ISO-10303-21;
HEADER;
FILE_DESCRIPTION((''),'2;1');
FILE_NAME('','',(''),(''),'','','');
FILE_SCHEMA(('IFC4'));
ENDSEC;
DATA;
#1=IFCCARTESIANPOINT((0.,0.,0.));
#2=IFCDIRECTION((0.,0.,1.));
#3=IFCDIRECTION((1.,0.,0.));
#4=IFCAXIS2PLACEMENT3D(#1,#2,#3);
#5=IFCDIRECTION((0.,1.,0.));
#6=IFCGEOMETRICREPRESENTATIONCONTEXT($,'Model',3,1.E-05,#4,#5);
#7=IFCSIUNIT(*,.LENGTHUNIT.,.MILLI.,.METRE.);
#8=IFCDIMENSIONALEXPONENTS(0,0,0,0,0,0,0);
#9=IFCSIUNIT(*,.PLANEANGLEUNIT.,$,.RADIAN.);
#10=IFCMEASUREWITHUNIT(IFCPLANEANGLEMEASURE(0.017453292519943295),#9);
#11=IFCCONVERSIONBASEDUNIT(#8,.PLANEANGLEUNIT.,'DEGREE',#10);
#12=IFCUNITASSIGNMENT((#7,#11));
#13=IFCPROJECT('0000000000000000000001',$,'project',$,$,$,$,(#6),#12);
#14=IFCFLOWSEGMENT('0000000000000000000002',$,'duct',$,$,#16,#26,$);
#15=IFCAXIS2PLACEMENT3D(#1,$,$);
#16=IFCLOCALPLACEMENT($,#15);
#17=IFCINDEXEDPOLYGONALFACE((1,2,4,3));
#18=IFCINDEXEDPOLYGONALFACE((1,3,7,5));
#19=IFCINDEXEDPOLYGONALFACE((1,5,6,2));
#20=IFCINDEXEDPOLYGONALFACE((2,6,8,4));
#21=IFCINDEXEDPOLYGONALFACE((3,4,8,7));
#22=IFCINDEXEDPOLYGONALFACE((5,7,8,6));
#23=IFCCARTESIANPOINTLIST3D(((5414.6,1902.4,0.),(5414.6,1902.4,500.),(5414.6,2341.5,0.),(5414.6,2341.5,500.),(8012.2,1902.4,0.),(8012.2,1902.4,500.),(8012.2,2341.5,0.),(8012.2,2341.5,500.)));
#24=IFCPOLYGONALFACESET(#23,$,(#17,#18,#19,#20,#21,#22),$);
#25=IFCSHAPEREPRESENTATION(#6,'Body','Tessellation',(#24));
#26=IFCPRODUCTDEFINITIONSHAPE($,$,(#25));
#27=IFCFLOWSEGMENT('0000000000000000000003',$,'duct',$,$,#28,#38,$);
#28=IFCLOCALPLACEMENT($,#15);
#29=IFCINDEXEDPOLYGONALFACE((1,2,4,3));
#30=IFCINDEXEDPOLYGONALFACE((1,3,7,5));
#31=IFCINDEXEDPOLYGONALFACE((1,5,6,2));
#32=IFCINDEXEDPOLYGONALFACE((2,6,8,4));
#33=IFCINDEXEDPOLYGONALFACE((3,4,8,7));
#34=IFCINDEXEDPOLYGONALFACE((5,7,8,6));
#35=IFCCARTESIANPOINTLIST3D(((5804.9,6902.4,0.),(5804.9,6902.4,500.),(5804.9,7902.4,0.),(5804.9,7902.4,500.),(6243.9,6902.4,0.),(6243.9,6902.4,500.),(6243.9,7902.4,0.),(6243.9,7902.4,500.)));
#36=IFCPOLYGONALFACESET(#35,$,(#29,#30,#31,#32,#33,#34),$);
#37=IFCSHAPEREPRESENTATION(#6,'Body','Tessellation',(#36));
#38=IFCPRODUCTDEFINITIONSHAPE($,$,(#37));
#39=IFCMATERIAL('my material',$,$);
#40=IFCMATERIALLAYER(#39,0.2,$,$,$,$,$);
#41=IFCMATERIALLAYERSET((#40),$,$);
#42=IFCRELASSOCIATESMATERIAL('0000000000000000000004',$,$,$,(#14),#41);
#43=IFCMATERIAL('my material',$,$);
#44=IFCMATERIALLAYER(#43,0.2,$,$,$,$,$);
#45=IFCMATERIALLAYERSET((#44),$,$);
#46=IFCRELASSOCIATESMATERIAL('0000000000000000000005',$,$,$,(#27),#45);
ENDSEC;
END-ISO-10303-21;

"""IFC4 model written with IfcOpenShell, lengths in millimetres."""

from ifc_helpers import new_model, entity, si_unit, converted_unit, direction, origin_with_axes, place, context, project, polyline, outline, extrude, material, layer, layer_set, layer_usage, element, save


model = new_model("IFC4")

# Units and contexts
model_context = context("Model", 3, precision=1e-05, world=origin_with_axes(), true_north=direction((0.0, 1.0, 0.0)))
ifc_project = project(units=[si_unit("LENGTHUNIT", "METRE", prefix="MILLI"), converted_unit("PLANEANGLEUNIT", "DEGREE", entity("IfcPlaneAngleMeasure", 0.017453292519943295), si_unit("PLANEANGLEUNIT", "RADIAN"), dimensions=[0, 0, 0, 0, 0, 0, 0])], contexts=[model_context])

# Flow segments
ifc_material_1 = material(Name="my material")
ifc_layer_1 = layer(ifc_material_1, 0.2)
ifc_layer_set_1 = layer_set([ifc_layer_1])
ifc_layer_usage_1 = layer_usage(ifc_layer_set_1, "AXIS2", "POSITIVE", -0.1)
flow_segment_1_placement = place(None, origin_with_axes())
element("IfcFlowSegment", 1, at=flow_segment_1_placement, material=ifc_layer_usage_1, Name="duct", context=model_context, shape_type="SweptSolid", body=[
    extrude(outline(polyline([(5414.6, 1902.4), (8012.2, 1902.4), (8012.2, 2341.5), (5414.6, 2341.5), (5414.6, 1902.4)])), origin_with_axes(), (0.0, 0.0, 1.0), 500.0),
])
ifc_material_2 = material(Name="my material")
ifc_layer_2 = layer(ifc_material_2, 0.2)
ifc_layer_set_2 = layer_set([ifc_layer_2])
ifc_layer_usage_2 = layer_usage(ifc_layer_set_2, "AXIS2", "POSITIVE", -0.1)
flow_segment_2_placement = place(None, origin_with_axes())
element("IfcFlowSegment", 2, at=flow_segment_2_placement, material=ifc_layer_usage_2, Name="duct", context=model_context, shape_type="SweptSolid", body=[
    extrude(outline(polyline([(5804.9, 6902.4), (6243.9, 6902.4), (6243.9, 7902.4), (5804.9, 7902.4), (5804.9, 6902.4)])), origin_with_axes(), (0.0, 0.0, 1.0), 500.0),
])

save(model, "model.ifc")
